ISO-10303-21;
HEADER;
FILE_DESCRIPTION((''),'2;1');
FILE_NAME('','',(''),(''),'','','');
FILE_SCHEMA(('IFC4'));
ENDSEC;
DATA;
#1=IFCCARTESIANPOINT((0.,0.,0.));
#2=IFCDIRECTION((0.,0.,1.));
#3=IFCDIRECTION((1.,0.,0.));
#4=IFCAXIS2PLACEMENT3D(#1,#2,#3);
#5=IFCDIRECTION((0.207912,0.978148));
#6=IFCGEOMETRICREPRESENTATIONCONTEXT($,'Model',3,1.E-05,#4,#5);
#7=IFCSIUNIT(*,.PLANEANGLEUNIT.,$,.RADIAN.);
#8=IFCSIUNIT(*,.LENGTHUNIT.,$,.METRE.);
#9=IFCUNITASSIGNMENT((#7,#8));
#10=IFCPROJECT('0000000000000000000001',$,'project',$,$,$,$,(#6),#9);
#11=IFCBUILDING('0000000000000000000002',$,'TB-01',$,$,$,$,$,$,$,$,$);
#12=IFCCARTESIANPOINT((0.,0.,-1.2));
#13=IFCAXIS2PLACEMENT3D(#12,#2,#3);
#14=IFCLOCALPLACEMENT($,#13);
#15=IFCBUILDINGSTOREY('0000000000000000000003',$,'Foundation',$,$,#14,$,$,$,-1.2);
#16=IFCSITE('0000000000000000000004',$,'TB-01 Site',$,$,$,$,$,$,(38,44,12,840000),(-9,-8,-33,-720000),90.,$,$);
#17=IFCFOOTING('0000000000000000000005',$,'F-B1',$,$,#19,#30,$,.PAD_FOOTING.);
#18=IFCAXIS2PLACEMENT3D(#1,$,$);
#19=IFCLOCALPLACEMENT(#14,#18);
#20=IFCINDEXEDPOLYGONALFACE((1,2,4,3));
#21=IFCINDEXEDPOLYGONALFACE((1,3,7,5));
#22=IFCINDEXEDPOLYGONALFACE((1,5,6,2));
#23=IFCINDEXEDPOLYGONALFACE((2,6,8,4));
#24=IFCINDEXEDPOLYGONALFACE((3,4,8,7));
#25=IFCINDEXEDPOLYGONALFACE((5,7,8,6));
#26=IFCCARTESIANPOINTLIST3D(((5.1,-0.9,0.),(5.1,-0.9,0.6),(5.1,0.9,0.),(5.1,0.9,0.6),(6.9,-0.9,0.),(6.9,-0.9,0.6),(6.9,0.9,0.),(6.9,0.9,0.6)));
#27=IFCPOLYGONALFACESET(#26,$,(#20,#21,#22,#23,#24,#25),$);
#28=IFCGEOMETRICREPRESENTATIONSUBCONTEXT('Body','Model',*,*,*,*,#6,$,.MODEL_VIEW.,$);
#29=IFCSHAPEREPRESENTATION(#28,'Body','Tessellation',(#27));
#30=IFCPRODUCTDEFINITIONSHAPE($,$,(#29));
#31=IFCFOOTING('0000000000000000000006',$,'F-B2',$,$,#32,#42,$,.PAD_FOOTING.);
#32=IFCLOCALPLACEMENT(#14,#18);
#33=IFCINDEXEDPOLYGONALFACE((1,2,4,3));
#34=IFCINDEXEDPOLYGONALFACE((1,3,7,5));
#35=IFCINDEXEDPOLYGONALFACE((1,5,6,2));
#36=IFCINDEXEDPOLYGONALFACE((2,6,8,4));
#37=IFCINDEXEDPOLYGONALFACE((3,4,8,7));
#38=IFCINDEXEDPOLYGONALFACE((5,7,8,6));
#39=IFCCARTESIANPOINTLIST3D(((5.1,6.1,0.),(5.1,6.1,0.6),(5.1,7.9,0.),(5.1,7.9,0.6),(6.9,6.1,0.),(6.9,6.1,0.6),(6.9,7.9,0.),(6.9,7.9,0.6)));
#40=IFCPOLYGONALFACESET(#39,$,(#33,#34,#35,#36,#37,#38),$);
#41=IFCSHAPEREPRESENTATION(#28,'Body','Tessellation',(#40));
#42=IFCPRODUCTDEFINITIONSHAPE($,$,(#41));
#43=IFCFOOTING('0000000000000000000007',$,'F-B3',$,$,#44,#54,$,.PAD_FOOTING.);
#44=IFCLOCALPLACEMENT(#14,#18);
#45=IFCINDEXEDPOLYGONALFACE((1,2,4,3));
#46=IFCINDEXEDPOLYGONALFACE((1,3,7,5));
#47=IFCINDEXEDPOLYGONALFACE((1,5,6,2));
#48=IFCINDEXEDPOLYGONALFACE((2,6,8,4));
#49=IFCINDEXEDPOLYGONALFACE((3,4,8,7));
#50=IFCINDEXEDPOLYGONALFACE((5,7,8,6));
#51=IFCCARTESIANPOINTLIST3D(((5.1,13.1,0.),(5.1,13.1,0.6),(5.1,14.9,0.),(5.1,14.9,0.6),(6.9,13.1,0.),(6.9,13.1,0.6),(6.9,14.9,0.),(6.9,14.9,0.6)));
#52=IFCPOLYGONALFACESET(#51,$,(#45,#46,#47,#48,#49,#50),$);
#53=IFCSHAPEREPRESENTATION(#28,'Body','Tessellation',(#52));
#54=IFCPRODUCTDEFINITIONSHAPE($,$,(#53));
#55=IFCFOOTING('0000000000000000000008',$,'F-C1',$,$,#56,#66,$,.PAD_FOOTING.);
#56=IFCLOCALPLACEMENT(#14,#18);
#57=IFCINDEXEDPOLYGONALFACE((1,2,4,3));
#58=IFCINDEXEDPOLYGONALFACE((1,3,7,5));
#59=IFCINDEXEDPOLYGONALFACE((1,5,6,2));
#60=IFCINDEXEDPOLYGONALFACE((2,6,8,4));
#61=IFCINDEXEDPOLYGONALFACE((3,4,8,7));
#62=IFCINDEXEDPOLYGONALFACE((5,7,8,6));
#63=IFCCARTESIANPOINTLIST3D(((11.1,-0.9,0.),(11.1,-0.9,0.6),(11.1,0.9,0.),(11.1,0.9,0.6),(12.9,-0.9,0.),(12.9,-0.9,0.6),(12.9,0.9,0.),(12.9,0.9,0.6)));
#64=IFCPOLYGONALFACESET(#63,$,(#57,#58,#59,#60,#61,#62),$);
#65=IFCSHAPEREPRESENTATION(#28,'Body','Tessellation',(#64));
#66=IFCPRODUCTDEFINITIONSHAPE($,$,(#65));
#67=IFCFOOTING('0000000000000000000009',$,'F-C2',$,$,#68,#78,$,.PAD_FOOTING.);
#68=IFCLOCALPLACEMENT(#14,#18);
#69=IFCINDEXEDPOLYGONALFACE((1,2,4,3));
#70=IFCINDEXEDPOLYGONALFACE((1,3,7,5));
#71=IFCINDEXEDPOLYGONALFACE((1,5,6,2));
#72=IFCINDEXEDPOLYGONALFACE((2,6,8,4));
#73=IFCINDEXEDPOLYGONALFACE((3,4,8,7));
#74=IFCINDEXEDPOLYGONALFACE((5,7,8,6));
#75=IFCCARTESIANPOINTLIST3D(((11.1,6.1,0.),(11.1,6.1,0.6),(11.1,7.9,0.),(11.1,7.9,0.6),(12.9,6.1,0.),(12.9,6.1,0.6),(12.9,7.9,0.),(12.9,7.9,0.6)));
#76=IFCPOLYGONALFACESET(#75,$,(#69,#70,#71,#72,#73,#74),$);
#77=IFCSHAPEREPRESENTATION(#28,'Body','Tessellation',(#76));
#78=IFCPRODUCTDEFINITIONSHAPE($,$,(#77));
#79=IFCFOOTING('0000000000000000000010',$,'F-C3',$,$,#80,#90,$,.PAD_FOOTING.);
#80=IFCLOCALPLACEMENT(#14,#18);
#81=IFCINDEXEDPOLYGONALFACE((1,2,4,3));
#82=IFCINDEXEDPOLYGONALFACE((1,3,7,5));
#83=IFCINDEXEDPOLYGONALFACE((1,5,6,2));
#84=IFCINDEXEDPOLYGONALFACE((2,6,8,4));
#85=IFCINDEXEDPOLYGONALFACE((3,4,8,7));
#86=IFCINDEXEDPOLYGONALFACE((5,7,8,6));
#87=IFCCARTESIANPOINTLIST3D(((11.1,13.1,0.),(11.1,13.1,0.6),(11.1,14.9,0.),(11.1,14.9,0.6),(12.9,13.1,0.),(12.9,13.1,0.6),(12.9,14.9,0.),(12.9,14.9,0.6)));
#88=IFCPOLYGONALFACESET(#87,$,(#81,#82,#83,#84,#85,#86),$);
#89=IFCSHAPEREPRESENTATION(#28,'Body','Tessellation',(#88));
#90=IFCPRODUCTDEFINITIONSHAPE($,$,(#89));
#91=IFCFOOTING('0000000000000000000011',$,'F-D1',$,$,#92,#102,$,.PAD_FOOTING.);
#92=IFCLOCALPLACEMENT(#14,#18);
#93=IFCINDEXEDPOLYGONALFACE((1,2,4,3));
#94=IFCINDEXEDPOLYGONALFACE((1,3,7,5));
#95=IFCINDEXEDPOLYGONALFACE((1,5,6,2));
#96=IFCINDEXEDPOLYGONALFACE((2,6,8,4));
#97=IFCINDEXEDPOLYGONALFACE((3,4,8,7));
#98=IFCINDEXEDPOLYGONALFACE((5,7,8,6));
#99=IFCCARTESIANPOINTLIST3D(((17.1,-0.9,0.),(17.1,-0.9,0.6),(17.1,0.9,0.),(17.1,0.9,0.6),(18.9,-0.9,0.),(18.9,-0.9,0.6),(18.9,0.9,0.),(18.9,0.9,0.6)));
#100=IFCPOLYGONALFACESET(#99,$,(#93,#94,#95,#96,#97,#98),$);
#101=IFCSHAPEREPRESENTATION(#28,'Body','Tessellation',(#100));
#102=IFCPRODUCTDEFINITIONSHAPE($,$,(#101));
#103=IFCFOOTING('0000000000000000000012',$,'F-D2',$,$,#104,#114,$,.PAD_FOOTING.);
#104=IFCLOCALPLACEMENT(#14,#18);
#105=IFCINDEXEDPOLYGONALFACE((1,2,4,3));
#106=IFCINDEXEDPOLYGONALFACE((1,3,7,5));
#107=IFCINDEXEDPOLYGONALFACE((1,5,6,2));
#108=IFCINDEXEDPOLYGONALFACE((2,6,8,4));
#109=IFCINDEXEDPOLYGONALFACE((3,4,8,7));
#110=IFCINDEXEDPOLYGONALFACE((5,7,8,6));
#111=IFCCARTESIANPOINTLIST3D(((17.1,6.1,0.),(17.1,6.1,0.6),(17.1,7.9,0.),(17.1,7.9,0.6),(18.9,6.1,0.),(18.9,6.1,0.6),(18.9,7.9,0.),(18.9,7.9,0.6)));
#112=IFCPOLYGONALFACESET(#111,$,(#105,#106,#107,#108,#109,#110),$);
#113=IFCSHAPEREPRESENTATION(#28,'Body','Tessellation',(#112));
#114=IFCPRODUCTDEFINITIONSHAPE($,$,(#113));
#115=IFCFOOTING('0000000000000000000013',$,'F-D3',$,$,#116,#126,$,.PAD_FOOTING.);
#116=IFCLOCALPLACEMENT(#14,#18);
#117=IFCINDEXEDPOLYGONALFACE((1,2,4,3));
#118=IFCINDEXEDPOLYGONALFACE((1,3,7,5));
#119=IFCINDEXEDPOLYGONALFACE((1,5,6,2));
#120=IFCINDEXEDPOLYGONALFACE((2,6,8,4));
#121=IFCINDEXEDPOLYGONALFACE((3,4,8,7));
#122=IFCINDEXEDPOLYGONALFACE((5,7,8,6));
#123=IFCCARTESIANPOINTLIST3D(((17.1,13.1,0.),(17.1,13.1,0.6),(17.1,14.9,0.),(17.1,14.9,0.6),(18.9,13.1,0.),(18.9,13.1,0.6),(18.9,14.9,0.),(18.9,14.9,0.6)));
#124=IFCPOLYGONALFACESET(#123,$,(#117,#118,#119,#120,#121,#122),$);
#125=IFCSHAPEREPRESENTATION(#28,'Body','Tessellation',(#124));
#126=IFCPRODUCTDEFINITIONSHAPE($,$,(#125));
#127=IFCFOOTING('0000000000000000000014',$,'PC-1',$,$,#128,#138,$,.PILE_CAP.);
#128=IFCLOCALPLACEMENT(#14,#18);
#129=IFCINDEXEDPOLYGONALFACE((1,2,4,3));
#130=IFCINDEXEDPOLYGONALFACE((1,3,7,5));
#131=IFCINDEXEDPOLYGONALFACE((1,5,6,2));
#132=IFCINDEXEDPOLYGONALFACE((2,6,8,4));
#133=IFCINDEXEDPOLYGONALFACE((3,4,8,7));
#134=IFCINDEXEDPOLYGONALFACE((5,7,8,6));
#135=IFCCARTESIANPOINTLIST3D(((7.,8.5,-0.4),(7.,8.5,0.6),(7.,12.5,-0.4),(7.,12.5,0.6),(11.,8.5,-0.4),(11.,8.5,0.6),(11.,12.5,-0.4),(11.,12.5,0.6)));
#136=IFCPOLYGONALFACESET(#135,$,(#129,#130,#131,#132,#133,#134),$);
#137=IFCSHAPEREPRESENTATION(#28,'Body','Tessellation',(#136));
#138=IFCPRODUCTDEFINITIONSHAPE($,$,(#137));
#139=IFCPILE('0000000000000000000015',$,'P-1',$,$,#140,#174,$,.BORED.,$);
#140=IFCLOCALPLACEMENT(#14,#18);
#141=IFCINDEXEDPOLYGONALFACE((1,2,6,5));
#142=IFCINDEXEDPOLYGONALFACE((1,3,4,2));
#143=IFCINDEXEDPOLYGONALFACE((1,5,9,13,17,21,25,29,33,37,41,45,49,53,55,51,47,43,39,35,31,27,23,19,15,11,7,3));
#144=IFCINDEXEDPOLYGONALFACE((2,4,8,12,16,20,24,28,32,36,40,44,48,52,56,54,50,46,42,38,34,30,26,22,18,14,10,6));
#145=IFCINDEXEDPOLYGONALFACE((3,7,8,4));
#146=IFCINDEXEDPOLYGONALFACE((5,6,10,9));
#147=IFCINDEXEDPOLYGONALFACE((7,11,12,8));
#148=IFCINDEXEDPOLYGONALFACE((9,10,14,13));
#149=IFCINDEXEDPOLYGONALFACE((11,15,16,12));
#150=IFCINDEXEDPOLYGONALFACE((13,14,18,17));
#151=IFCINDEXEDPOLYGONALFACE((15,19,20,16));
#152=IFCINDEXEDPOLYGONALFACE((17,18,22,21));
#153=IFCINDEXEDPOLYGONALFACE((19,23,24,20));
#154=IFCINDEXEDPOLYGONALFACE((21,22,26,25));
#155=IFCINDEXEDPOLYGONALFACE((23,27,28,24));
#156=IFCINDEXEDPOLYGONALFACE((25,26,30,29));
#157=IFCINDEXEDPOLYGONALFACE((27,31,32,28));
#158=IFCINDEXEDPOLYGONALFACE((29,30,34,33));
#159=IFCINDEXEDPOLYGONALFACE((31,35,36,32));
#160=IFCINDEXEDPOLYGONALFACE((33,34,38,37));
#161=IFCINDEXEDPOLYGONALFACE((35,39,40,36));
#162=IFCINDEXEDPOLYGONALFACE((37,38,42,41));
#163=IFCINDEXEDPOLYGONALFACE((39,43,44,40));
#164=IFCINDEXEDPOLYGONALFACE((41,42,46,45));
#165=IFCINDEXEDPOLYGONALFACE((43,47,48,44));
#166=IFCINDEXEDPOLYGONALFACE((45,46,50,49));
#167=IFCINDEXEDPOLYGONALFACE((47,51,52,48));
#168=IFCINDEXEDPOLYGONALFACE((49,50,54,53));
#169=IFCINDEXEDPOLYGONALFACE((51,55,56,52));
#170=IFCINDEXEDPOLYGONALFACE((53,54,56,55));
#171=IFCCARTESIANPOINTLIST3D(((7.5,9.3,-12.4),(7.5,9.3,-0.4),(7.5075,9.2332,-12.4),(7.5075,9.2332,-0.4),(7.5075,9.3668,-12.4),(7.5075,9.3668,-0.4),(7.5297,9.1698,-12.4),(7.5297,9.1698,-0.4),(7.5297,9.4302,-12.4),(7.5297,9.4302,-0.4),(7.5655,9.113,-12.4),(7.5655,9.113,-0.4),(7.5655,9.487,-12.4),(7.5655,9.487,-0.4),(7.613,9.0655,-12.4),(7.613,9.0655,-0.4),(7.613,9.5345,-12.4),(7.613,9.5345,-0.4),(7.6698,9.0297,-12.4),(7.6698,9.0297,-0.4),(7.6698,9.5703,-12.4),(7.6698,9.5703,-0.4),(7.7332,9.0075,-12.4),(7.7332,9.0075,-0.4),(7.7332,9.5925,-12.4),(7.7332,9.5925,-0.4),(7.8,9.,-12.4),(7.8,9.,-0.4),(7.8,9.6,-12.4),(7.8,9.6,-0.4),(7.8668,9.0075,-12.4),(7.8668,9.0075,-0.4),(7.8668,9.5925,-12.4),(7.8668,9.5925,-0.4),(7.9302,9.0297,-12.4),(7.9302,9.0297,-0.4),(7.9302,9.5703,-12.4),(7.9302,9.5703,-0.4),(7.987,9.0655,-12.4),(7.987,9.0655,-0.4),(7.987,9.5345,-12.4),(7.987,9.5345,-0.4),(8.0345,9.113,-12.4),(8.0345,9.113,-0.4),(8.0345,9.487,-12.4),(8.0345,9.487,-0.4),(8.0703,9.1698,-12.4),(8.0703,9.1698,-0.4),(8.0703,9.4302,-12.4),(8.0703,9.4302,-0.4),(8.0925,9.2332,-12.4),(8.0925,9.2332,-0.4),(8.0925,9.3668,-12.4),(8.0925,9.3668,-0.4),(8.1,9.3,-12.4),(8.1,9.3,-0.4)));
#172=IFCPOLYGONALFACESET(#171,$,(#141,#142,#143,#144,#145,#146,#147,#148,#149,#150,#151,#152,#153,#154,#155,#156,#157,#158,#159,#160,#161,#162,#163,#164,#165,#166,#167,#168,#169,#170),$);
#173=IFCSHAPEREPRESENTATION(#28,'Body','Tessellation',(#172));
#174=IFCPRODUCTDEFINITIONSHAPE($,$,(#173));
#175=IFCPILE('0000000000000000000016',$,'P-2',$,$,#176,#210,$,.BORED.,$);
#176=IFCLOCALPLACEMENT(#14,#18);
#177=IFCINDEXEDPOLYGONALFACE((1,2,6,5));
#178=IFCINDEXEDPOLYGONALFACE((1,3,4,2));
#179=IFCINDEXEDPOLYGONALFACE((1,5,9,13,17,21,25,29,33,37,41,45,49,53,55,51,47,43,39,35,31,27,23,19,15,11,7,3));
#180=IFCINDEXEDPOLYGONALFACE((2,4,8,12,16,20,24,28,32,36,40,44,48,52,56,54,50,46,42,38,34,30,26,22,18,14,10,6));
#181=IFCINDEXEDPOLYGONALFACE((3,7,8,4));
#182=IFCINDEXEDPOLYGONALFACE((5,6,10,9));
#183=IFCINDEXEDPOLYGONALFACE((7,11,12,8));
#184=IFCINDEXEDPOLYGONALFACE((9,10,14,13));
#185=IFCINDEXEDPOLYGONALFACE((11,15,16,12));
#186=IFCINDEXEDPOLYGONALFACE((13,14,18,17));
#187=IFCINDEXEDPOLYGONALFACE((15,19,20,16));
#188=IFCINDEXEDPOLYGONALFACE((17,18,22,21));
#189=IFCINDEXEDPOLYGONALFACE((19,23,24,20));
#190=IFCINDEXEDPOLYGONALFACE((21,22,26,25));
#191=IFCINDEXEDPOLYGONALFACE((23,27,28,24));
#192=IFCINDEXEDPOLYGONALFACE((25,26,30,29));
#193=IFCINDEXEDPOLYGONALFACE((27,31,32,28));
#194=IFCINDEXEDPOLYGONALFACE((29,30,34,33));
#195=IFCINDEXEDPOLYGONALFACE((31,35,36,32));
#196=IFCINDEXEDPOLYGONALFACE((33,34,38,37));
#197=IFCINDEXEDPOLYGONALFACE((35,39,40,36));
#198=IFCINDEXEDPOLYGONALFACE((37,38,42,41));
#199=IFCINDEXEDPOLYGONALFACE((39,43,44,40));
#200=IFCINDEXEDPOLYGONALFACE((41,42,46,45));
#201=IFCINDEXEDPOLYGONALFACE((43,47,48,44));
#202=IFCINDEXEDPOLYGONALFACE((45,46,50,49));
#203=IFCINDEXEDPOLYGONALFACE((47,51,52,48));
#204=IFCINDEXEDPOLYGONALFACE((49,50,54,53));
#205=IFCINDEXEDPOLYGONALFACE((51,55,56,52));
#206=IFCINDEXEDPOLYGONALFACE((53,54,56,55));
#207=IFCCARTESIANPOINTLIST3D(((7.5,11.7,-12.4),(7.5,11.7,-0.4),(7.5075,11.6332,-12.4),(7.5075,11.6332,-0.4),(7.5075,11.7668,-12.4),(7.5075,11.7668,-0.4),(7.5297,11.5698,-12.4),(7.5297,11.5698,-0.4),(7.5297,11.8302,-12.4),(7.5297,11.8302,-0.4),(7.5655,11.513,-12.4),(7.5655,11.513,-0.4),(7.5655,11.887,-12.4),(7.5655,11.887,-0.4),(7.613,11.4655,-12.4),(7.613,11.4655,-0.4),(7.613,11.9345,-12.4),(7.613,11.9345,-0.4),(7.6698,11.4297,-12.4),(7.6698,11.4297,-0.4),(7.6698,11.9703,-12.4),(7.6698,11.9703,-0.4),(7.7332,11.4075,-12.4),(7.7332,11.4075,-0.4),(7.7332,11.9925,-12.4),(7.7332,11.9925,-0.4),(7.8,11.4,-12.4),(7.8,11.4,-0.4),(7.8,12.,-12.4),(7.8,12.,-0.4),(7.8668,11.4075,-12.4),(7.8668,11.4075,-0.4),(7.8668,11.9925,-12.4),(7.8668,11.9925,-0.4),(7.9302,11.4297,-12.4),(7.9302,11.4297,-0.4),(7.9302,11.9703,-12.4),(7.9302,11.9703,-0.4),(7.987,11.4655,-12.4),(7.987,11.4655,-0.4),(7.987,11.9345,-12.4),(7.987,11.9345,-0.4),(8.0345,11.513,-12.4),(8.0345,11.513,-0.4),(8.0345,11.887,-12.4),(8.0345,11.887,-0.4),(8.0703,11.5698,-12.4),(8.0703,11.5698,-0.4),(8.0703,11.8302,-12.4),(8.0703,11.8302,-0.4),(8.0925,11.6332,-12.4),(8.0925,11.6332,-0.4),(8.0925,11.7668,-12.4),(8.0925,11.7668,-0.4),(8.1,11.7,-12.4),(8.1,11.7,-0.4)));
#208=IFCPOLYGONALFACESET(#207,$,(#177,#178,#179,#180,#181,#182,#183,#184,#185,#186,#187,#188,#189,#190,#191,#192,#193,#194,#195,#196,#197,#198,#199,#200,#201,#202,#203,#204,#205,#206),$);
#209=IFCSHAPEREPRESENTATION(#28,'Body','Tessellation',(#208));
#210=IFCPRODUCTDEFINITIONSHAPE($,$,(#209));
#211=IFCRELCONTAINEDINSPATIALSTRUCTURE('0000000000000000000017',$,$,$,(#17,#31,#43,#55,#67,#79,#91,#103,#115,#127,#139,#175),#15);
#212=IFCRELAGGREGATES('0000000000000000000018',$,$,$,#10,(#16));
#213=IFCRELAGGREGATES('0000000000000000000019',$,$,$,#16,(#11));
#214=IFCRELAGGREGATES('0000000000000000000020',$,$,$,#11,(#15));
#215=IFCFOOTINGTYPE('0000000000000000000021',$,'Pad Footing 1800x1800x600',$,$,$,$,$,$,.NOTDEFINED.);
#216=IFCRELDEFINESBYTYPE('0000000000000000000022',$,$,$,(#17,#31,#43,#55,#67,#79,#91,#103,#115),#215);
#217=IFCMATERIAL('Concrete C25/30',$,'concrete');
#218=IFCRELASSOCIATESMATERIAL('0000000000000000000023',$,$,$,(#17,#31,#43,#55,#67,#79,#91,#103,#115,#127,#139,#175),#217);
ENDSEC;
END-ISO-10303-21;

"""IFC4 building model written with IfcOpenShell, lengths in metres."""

from ifc_helpers import new_model, si_unit, direction, frame, origin_with_axes, place, context, subcontext, project, spatial, rectangle, circle, extrude, material, type_object, element, save


model = new_model("IFC4")

# Units and contexts
model_context = context("Model", 3, precision=1e-05, world=origin_with_axes(), true_north=direction((0.207912, 0.978148)))
body_context = subcontext(model_context, "Body", "Model", "MODEL_VIEW")
ifc_project = project(units=[si_unit("PLANEANGLEUNIT", "RADIAN"), si_unit("LENGTHUNIT", "METRE")], contexts=[model_context])

# Site, building, storey
site = spatial("IfcSite", under=ifc_project, Name="TB-01 Site", RefLatitude=(38, 44, 12, 840000), RefLongitude=(-9, -8, -33, -720000), RefElevation=90.0)
building = spatial("IfcBuilding", under=site, Name="TB-01")
storey_placement = place(None, frame((0.0, 0.0, -1.2), z_axis=(0.0, 0.0, 1.0), x_axis=(1.0, 0.0, 0.0)))
storey = spatial("IfcBuildingStorey", under=building, at=storey_placement, Name="Foundation", Elevation=-1.2)

# Footings
ifc_material_1 = material(Name="Concrete C25/30", Category="concrete")
footing_type = type_object("IfcFootingType", Name="Pad Footing 1800x1800x600", PredefinedType="NOTDEFINED")
footing_1_placement = place(storey_placement, frame((6.0, 0.0, 0.0), z_axis=(0.0, 0.0, 1.0), x_axis=(1.0, 0.0, 0.0)))
element("IfcFooting", 1, at=footing_1_placement, inside=storey, type_object=footing_type, material=ifc_material_1, Name="F-B1", PredefinedType="PAD_FOOTING", context=body_context, shape_type="SweptSolid", body=[
    extrude(rectangle(XDim=1.8, YDim=1.8), origin_with_axes(), (0.0, 0.0, 1.0), 0.6),
])
for number, where, z_axis, x_axis, name in (
    (2, (6.0, 7.0, 0.0), (0.0, 0.0, 1.0), (1.0, 0.0, 0.0), "F-B2"),
    (3, (6.0, 14.0, 0.0), (0.0, 0.0, 1.0), (1.0, 0.0, 0.0), "F-B3"),
):
    element("IfcFooting", number, at=place(storey_placement, frame(where, z_axis=z_axis, x_axis=x_axis)), inside=storey, type_object=footing_type, material=ifc_material_1, Name=name, PredefinedType="PAD_FOOTING", context=body_context, shape_type="SweptSolid", body=[
        extrude(rectangle(XDim=1.8, YDim=1.8), origin_with_axes(), (0.0, 0.0, 1.0), 0.6),
    ])
footing_2_placement = place(storey_placement, frame((12.0, 0.0, 0.0), z_axis=(0.0, 0.0, 1.0), x_axis=(1.0, 0.0, 0.0)))
element("IfcFooting", 4, at=footing_2_placement, inside=storey, type_object=footing_type, material=ifc_material_1, Name="F-C1", PredefinedType="PAD_FOOTING", context=body_context, shape_type="SweptSolid", body=[
    extrude(rectangle(XDim=1.8, YDim=1.8), origin_with_axes(), (0.0, 0.0, 1.0), 0.6),
])
for number, where, z_axis, x_axis, name in (
    (5, (12.0, 7.0, 0.0), (0.0, 0.0, 1.0), (1.0, 0.0, 0.0), "F-C2"),
    (6, (12.0, 14.0, 0.0), (0.0, 0.0, 1.0), (1.0, 0.0, 0.0), "F-C3"),
):
    element("IfcFooting", number, at=place(storey_placement, frame(where, z_axis=z_axis, x_axis=x_axis)), inside=storey, type_object=footing_type, material=ifc_material_1, Name=name, PredefinedType="PAD_FOOTING", context=body_context, shape_type="SweptSolid", body=[
        extrude(rectangle(XDim=1.8, YDim=1.8), origin_with_axes(), (0.0, 0.0, 1.0), 0.6),
    ])
footing_3_placement = place(storey_placement, frame((18.0, 0.0, 0.0), z_axis=(0.0, 0.0, 1.0), x_axis=(1.0, 0.0, 0.0)))
element("IfcFooting", 7, at=footing_3_placement, inside=storey, type_object=footing_type, material=ifc_material_1, Name="F-D1", PredefinedType="PAD_FOOTING", context=body_context, shape_type="SweptSolid", body=[
    extrude(rectangle(XDim=1.8, YDim=1.8), origin_with_axes(), (0.0, 0.0, 1.0), 0.6),
])
for number, where, z_axis, x_axis, name in (
    (8, (18.0, 7.0, 0.0), (0.0, 0.0, 1.0), (1.0, 0.0, 0.0), "F-D2"),
    (9, (18.0, 14.0, 0.0), (0.0, 0.0, 1.0), (1.0, 0.0, 0.0), "F-D3"),
):
    element("IfcFooting", number, at=place(storey_placement, frame(where, z_axis=z_axis, x_axis=x_axis)), inside=storey, type_object=footing_type, material=ifc_material_1, Name=name, PredefinedType="PAD_FOOTING", context=body_context, shape_type="SweptSolid", body=[
        extrude(rectangle(XDim=1.8, YDim=1.8), origin_with_axes(), (0.0, 0.0, 1.0), 0.6),
    ])
footing_4_placement = place(storey_placement, frame((9.0, 10.5, -0.4), z_axis=(0.0, 0.0, 1.0), x_axis=(1.0, 0.0, 0.0)))
element("IfcFooting", 10, at=footing_4_placement, inside=storey, material=ifc_material_1, Name="PC-1", PredefinedType="PILE_CAP", context=body_context, shape_type="SweptSolid", body=[
    extrude(rectangle(XDim=4.0, YDim=4.0), origin_with_axes(), (0.0, 0.0, 1.0), 1.0),
])

# Piles
for number, where, z_axis, x_axis, name in (
    (11, (7.8, 9.3, -12.4), (0.0, 0.0, 1.0), (1.0, 0.0, 0.0), "P-1"),
    (12, (7.8, 11.7, -12.4), (0.0, 0.0, 1.0), (1.0, 0.0, 0.0), "P-2"),
):
    element("IfcPile", number, at=place(storey_placement, frame(where, z_axis=z_axis, x_axis=x_axis)), inside=storey, material=ifc_material_1, Name=name, PredefinedType="BORED", context=body_context, shape_type="SweptSolid", body=[
        extrude(circle(Radius=0.3), origin_with_axes(), (0.0, 0.0, 1.0), 12.0),
    ])

save(model, "model.ifc")
